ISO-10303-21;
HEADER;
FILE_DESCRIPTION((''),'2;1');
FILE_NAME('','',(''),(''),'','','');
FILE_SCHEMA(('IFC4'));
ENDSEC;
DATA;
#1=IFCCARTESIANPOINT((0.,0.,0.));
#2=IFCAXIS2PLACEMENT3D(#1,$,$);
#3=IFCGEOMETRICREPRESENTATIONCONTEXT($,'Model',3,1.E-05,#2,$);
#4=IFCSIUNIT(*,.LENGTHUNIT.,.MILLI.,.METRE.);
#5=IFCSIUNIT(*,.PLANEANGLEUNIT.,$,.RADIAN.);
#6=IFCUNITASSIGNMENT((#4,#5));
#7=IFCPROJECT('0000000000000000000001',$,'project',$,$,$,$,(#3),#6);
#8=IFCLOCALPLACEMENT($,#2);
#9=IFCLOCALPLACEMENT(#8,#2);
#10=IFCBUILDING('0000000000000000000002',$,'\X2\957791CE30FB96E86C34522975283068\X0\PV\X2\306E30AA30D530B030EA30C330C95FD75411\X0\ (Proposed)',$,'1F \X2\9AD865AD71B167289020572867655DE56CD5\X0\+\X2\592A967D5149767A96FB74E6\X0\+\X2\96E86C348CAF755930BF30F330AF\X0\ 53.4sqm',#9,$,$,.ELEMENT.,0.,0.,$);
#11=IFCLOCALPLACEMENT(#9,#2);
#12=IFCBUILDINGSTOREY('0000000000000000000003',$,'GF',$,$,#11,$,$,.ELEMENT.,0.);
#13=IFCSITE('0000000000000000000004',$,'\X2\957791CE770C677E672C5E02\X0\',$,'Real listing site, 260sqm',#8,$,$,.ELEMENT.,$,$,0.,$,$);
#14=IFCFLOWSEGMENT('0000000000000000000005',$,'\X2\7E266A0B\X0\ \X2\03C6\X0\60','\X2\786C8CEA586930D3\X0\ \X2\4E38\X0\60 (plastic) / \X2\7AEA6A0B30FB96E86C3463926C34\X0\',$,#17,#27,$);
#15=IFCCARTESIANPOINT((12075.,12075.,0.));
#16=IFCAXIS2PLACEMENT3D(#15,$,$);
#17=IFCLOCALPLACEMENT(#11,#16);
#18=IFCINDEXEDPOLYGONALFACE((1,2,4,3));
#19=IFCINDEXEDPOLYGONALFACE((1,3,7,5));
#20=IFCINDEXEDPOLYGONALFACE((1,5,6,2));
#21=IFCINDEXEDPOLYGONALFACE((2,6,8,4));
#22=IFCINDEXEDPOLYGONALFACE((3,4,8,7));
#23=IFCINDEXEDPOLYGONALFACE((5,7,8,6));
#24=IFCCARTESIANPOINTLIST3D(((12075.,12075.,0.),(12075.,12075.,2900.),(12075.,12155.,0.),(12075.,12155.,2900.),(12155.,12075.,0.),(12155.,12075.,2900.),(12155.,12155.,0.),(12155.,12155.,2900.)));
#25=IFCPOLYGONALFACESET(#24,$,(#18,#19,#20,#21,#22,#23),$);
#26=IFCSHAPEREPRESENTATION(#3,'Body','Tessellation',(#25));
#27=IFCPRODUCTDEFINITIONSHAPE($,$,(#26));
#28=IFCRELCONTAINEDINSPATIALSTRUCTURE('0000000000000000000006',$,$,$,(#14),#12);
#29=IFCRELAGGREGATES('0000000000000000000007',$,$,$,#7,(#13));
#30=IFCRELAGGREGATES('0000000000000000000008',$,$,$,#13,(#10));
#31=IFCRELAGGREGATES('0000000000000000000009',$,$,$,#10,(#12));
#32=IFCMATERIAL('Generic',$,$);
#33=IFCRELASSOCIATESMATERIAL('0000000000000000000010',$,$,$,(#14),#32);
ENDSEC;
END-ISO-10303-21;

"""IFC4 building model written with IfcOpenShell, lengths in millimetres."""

from ifc_helpers import new_model, si_unit, frame, frame_2d, origin, place, context, project, spatial, rectangle, extrude, material, element, save


model = new_model("IFC4")

# Units and contexts
model_context = context("Model", 3, precision=1e-05, world=origin())
ifc_project = project(units=[si_unit("LENGTHUNIT", "METRE", prefix="MILLI"), si_unit("PLANEANGLEUNIT", "RADIAN")], contexts=[model_context])

# Site, building, storey
site_placement = place(None, origin())
site = spatial("IfcSite", under=ifc_project, at=site_placement, Name="長野県松本市", ObjectType="Real listing site, 260sqm", CompositionType="ELEMENT", RefElevation=0.0)
building_placement = place(site_placement, origin())
building = spatial("IfcBuilding", under=site, at=building_placement, Name="長野・雨水利用とPVのオフグリッド志向 (Proposed)", ObjectType="1F 高断熱木造在来工法+太陽光発電瓦+雨水貯留タンク 53.4sqm", CompositionType="ELEMENT", ElevationOfRefHeight=0.0, ElevationOfTerrain=0.0)
storey_placement = place(building_placement, origin())
storey = spatial("IfcBuildingStorey", under=building, at=storey_placement, Name="GF", CompositionType="ELEMENT", Elevation=0.0)

# Shared definitions
ifc_material_1 = material(Name="Generic")

# Flow segment
flow_segment_placement = place(storey_placement, frame((12075.0, 12075.0, 0.0)))
element("IfcFlowSegment", 1, at=flow_segment_placement, inside=storey, material=ifc_material_1, Name="縦樋 φ60", Description="硬質塩ビ 丸60 (plastic) / 竪樋・雨水排水", context=model_context, shape_type="SweptSolid", body=[
    extrude(rectangle(XDim=80.0, YDim=80.0, at=frame_2d((40.0, 40.0))), frame((12075.0, 12075.0, 0.0)), (0.0, 0.0, 1.0), 2900.0),
])

save(model, "model.ifc")
